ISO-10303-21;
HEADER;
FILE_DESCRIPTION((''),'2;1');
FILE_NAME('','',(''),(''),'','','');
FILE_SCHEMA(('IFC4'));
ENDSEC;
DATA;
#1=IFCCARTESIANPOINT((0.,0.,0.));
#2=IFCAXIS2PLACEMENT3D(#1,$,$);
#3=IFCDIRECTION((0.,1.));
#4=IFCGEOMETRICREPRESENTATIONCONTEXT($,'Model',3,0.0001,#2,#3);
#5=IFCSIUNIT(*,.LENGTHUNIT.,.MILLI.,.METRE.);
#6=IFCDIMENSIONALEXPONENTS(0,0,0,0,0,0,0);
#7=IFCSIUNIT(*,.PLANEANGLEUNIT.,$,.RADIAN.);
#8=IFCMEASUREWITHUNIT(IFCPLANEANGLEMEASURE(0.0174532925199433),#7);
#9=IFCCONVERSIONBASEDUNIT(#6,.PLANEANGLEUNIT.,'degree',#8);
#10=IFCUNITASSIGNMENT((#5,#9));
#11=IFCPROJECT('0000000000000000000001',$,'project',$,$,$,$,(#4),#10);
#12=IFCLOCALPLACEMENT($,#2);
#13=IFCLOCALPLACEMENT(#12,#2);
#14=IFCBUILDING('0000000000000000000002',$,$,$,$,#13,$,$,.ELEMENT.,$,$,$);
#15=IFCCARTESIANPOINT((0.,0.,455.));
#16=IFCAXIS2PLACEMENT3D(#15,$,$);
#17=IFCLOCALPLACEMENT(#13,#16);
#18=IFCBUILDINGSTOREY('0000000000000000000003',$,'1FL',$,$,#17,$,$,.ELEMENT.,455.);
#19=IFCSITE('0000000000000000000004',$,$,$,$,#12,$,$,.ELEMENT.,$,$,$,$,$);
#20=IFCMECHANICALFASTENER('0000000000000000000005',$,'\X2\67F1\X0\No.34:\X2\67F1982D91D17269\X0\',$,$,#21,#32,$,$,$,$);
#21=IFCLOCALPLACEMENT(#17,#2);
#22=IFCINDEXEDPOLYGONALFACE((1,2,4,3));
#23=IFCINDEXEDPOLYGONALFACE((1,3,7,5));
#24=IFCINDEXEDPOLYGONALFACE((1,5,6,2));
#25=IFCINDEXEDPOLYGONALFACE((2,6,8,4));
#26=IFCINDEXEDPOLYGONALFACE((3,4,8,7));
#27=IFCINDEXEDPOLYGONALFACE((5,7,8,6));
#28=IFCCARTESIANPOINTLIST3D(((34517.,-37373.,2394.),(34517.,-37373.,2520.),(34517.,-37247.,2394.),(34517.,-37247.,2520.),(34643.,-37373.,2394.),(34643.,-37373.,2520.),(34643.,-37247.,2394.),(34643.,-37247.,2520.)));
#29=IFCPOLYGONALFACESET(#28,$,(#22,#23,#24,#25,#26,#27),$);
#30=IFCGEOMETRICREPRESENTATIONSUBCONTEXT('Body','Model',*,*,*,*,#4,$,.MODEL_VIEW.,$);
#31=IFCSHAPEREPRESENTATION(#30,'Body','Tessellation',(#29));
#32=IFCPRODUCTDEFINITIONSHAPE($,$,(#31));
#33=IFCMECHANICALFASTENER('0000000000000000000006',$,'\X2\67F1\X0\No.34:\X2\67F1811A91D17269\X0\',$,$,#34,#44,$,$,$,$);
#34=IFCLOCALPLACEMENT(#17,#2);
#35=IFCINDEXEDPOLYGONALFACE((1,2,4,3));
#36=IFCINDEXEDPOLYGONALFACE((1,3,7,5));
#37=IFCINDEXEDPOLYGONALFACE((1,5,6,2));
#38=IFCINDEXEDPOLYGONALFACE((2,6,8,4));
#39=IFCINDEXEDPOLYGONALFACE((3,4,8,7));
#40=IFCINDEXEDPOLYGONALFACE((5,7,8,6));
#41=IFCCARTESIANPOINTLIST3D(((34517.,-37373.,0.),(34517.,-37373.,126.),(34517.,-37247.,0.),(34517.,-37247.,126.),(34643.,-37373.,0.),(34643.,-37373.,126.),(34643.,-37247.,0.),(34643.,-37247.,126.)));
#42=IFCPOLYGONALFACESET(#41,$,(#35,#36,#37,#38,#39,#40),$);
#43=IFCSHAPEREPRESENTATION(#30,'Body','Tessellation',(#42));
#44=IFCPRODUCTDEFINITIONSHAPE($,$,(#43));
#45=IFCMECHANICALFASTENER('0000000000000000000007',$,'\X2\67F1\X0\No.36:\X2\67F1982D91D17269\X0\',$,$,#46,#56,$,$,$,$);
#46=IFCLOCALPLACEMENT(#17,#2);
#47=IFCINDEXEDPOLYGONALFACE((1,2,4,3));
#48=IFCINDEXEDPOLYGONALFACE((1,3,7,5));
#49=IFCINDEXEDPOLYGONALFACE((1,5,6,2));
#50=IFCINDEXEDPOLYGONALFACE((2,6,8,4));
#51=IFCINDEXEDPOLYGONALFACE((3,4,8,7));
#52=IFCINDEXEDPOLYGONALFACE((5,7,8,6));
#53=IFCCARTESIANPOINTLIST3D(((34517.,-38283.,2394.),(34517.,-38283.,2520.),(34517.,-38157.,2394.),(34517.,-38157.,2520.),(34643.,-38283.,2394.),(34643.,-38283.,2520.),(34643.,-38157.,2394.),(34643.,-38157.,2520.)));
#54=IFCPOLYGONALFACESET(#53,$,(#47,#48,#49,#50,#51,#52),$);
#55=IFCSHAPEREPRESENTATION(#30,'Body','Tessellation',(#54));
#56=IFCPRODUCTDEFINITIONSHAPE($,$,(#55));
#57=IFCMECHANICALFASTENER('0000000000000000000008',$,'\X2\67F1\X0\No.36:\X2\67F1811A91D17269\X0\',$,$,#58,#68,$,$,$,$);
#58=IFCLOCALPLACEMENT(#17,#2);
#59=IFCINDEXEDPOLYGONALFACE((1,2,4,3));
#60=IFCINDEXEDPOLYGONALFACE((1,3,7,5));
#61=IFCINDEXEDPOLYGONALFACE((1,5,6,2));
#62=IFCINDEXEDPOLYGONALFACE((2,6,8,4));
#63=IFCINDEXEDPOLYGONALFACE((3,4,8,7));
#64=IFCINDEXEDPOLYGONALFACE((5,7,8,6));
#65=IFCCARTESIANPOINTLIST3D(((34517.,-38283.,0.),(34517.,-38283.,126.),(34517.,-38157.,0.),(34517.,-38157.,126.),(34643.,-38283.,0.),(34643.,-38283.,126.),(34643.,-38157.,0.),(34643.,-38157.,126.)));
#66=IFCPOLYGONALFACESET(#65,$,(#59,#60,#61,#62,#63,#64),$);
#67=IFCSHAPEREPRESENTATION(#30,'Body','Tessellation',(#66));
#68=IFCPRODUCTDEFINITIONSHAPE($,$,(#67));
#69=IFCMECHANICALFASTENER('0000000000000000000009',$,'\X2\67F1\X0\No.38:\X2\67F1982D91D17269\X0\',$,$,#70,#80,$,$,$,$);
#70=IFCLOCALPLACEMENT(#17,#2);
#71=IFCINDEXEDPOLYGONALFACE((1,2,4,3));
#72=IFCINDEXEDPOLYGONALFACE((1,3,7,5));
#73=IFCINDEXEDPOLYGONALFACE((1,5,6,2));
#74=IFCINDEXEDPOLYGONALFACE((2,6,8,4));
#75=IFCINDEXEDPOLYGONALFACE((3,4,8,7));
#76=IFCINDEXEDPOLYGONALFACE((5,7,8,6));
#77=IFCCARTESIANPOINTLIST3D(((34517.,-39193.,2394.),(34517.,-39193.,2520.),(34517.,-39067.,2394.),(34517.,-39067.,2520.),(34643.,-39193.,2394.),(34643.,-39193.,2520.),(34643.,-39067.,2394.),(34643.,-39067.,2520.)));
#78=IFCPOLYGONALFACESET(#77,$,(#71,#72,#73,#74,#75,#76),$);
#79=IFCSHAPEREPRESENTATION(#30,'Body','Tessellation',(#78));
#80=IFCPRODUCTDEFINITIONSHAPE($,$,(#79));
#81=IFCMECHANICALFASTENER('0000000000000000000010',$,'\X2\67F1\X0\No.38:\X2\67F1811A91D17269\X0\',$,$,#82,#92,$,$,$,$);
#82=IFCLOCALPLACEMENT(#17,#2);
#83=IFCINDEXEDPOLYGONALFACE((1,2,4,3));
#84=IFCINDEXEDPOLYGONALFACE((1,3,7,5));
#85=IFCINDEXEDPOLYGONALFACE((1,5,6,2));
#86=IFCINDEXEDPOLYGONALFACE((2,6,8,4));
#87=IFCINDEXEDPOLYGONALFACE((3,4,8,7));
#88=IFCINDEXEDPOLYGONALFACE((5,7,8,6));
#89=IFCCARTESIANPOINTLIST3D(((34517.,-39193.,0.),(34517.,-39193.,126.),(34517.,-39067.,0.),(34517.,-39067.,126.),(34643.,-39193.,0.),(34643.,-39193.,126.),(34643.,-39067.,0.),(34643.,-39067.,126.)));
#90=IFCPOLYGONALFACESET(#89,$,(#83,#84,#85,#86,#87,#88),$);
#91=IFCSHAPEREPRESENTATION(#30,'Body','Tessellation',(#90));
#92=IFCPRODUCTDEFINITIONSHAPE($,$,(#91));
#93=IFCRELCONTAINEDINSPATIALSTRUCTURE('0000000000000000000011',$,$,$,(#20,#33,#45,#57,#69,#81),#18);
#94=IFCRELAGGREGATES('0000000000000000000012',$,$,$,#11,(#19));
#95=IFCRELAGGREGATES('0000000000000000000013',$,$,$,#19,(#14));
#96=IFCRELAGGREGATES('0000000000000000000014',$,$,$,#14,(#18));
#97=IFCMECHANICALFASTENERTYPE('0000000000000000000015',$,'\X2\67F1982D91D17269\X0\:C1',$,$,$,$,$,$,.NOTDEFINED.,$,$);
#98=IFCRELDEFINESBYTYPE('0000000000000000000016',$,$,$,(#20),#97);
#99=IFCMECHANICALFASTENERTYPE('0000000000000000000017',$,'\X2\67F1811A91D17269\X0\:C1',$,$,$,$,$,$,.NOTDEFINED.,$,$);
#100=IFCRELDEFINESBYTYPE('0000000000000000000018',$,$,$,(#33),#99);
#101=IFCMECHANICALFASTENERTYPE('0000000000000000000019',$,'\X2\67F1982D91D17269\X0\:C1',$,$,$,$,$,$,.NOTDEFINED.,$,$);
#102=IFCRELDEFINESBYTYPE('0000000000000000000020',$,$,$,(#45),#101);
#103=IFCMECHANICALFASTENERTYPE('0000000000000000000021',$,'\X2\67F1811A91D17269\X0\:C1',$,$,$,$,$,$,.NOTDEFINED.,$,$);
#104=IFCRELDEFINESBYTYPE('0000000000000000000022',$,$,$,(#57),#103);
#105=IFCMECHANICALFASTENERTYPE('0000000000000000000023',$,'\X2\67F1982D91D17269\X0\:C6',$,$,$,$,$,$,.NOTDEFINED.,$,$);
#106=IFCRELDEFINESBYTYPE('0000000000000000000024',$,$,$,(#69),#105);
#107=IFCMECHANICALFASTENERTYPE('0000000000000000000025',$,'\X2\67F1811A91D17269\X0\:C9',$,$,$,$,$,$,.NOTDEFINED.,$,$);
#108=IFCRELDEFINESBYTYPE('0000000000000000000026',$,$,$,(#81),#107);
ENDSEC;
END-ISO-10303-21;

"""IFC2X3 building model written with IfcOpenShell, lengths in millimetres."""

from ifc_helpers import new_model, entity, si_unit, converted_unit, direction, frame, origin, origin_with_axes, origin_2d, place, context, subcontext, project, spatial, rectangle, extrude, type_object, element, save


model = new_model("IFC2X3")

# Units and contexts
model_context = context("Model", 3, precision=0.0001, world=origin(), true_north=direction((0.0, 1.0)))
body_context = subcontext(model_context, "Body", "Model", "MODEL_VIEW")
ifc_project = project(units=[si_unit("LENGTHUNIT", "METRE", prefix="MILLI"), converted_unit("PLANEANGLEUNIT", "degree", entity("IfcPlaneAngleMeasure", 0.0174532925199433), si_unit("PLANEANGLEUNIT", "RADIAN"), dimensions=[0, 0, 0, 0, 0, 0, 0])], contexts=[model_context])

# Site, building, storey
site_placement = place(None, origin())
site = spatial("IfcSite", under=ifc_project, at=site_placement, CompositionType="ELEMENT")
building_placement = place(site_placement, origin())
building = spatial("IfcBuilding", under=site, at=building_placement, CompositionType="ELEMENT")
storey_placement = place(building_placement, frame((0.0, 0.0, 455.0)))
storey = spatial("IfcBuildingStorey", under=building, at=storey_placement, Name="1FL", CompositionType="ELEMENT", Elevation=455.0)

# Mechanical fasteners
mechanical_fastener_type_1 = type_object("IfcMechanicalFastenerType", Name="柱頭金物:C1")
mechanical_fastener_1_placement = place(storey_placement, frame((34580.0, -37310.0, 2394.0)))
element("IfcMechanicalFastener", 1, at=mechanical_fastener_1_placement, inside=storey, type_object=mechanical_fastener_type_1, Name="柱No.34:柱頭金物", context=body_context, shape_type="SweptSolid", body=[
    extrude(rectangle(XDim=126.0, YDim=126.0, at=origin_2d()), origin_with_axes(), (0.0, 0.0, 1.0), 126.0),
])
mechanical_fastener_type_2 = type_object("IfcMechanicalFastenerType", Name="柱脚金物:C1")
mechanical_fastener_2_placement = place(storey_placement, frame((34580.0, -37310.0, 0.0)))
element("IfcMechanicalFastener", 2, at=mechanical_fastener_2_placement, inside=storey, type_object=mechanical_fastener_type_2, Name="柱No.34:柱脚金物", context=body_context, shape_type="SweptSolid", body=[
    extrude(rectangle(XDim=126.0, YDim=126.0, at=origin_2d()), origin_with_axes(), (0.0, 0.0, 1.0), 126.0),
])
mechanical_fastener_type_3 = type_object("IfcMechanicalFastenerType", Name="柱頭金物:C1")
mechanical_fastener_3_placement = place(storey_placement, frame((34580.0, -38220.0, 2394.0)))
element("IfcMechanicalFastener", 3, at=mechanical_fastener_3_placement, inside=storey, type_object=mechanical_fastener_type_3, Name="柱No.36:柱頭金物", context=body_context, shape_type="SweptSolid", body=[
    extrude(rectangle(XDim=126.0, YDim=126.0, at=origin_2d()), origin_with_axes(), (0.0, 0.0, 1.0), 126.0),
])
mechanical_fastener_type_4 = type_object("IfcMechanicalFastenerType", Name="柱脚金物:C1")
mechanical_fastener_4_placement = place(storey_placement, frame((34580.0, -38220.0, 0.0)))
element("IfcMechanicalFastener", 4, at=mechanical_fastener_4_placement, inside=storey, type_object=mechanical_fastener_type_4, Name="柱No.36:柱脚金物", context=body_context, shape_type="SweptSolid", body=[
    extrude(rectangle(XDim=126.0, YDim=126.0, at=origin_2d()), origin_with_axes(), (0.0, 0.0, 1.0), 126.0),
])
mechanical_fastener_type_5 = type_object("IfcMechanicalFastenerType", Name="柱頭金物:C6")
mechanical_fastener_5_placement = place(storey_placement, frame((34580.0, -39130.0, 2394.0)))
element("IfcMechanicalFastener", 5, at=mechanical_fastener_5_placement, inside=storey, type_object=mechanical_fastener_type_5, Name="柱No.38:柱頭金物", context=body_context, shape_type="SweptSolid", body=[
    extrude(rectangle(XDim=126.0, YDim=126.0, at=origin_2d()), origin_with_axes(), (0.0, 0.0, 1.0), 126.0),
])
mechanical_fastener_type_6 = type_object("IfcMechanicalFastenerType", Name="柱脚金物:C9")
mechanical_fastener_6_placement = place(storey_placement, frame((34580.0, -39130.0, 0.0)))
element("IfcMechanicalFastener", 6, at=mechanical_fastener_6_placement, inside=storey, type_object=mechanical_fastener_type_6, Name="柱No.38:柱脚金物", context=body_context, shape_type="SweptSolid", body=[
    extrude(rectangle(XDim=126.0, YDim=126.0, at=origin_2d()), origin_with_axes(), (0.0, 0.0, 1.0), 126.0),
])

save(model, "model.ifc")
